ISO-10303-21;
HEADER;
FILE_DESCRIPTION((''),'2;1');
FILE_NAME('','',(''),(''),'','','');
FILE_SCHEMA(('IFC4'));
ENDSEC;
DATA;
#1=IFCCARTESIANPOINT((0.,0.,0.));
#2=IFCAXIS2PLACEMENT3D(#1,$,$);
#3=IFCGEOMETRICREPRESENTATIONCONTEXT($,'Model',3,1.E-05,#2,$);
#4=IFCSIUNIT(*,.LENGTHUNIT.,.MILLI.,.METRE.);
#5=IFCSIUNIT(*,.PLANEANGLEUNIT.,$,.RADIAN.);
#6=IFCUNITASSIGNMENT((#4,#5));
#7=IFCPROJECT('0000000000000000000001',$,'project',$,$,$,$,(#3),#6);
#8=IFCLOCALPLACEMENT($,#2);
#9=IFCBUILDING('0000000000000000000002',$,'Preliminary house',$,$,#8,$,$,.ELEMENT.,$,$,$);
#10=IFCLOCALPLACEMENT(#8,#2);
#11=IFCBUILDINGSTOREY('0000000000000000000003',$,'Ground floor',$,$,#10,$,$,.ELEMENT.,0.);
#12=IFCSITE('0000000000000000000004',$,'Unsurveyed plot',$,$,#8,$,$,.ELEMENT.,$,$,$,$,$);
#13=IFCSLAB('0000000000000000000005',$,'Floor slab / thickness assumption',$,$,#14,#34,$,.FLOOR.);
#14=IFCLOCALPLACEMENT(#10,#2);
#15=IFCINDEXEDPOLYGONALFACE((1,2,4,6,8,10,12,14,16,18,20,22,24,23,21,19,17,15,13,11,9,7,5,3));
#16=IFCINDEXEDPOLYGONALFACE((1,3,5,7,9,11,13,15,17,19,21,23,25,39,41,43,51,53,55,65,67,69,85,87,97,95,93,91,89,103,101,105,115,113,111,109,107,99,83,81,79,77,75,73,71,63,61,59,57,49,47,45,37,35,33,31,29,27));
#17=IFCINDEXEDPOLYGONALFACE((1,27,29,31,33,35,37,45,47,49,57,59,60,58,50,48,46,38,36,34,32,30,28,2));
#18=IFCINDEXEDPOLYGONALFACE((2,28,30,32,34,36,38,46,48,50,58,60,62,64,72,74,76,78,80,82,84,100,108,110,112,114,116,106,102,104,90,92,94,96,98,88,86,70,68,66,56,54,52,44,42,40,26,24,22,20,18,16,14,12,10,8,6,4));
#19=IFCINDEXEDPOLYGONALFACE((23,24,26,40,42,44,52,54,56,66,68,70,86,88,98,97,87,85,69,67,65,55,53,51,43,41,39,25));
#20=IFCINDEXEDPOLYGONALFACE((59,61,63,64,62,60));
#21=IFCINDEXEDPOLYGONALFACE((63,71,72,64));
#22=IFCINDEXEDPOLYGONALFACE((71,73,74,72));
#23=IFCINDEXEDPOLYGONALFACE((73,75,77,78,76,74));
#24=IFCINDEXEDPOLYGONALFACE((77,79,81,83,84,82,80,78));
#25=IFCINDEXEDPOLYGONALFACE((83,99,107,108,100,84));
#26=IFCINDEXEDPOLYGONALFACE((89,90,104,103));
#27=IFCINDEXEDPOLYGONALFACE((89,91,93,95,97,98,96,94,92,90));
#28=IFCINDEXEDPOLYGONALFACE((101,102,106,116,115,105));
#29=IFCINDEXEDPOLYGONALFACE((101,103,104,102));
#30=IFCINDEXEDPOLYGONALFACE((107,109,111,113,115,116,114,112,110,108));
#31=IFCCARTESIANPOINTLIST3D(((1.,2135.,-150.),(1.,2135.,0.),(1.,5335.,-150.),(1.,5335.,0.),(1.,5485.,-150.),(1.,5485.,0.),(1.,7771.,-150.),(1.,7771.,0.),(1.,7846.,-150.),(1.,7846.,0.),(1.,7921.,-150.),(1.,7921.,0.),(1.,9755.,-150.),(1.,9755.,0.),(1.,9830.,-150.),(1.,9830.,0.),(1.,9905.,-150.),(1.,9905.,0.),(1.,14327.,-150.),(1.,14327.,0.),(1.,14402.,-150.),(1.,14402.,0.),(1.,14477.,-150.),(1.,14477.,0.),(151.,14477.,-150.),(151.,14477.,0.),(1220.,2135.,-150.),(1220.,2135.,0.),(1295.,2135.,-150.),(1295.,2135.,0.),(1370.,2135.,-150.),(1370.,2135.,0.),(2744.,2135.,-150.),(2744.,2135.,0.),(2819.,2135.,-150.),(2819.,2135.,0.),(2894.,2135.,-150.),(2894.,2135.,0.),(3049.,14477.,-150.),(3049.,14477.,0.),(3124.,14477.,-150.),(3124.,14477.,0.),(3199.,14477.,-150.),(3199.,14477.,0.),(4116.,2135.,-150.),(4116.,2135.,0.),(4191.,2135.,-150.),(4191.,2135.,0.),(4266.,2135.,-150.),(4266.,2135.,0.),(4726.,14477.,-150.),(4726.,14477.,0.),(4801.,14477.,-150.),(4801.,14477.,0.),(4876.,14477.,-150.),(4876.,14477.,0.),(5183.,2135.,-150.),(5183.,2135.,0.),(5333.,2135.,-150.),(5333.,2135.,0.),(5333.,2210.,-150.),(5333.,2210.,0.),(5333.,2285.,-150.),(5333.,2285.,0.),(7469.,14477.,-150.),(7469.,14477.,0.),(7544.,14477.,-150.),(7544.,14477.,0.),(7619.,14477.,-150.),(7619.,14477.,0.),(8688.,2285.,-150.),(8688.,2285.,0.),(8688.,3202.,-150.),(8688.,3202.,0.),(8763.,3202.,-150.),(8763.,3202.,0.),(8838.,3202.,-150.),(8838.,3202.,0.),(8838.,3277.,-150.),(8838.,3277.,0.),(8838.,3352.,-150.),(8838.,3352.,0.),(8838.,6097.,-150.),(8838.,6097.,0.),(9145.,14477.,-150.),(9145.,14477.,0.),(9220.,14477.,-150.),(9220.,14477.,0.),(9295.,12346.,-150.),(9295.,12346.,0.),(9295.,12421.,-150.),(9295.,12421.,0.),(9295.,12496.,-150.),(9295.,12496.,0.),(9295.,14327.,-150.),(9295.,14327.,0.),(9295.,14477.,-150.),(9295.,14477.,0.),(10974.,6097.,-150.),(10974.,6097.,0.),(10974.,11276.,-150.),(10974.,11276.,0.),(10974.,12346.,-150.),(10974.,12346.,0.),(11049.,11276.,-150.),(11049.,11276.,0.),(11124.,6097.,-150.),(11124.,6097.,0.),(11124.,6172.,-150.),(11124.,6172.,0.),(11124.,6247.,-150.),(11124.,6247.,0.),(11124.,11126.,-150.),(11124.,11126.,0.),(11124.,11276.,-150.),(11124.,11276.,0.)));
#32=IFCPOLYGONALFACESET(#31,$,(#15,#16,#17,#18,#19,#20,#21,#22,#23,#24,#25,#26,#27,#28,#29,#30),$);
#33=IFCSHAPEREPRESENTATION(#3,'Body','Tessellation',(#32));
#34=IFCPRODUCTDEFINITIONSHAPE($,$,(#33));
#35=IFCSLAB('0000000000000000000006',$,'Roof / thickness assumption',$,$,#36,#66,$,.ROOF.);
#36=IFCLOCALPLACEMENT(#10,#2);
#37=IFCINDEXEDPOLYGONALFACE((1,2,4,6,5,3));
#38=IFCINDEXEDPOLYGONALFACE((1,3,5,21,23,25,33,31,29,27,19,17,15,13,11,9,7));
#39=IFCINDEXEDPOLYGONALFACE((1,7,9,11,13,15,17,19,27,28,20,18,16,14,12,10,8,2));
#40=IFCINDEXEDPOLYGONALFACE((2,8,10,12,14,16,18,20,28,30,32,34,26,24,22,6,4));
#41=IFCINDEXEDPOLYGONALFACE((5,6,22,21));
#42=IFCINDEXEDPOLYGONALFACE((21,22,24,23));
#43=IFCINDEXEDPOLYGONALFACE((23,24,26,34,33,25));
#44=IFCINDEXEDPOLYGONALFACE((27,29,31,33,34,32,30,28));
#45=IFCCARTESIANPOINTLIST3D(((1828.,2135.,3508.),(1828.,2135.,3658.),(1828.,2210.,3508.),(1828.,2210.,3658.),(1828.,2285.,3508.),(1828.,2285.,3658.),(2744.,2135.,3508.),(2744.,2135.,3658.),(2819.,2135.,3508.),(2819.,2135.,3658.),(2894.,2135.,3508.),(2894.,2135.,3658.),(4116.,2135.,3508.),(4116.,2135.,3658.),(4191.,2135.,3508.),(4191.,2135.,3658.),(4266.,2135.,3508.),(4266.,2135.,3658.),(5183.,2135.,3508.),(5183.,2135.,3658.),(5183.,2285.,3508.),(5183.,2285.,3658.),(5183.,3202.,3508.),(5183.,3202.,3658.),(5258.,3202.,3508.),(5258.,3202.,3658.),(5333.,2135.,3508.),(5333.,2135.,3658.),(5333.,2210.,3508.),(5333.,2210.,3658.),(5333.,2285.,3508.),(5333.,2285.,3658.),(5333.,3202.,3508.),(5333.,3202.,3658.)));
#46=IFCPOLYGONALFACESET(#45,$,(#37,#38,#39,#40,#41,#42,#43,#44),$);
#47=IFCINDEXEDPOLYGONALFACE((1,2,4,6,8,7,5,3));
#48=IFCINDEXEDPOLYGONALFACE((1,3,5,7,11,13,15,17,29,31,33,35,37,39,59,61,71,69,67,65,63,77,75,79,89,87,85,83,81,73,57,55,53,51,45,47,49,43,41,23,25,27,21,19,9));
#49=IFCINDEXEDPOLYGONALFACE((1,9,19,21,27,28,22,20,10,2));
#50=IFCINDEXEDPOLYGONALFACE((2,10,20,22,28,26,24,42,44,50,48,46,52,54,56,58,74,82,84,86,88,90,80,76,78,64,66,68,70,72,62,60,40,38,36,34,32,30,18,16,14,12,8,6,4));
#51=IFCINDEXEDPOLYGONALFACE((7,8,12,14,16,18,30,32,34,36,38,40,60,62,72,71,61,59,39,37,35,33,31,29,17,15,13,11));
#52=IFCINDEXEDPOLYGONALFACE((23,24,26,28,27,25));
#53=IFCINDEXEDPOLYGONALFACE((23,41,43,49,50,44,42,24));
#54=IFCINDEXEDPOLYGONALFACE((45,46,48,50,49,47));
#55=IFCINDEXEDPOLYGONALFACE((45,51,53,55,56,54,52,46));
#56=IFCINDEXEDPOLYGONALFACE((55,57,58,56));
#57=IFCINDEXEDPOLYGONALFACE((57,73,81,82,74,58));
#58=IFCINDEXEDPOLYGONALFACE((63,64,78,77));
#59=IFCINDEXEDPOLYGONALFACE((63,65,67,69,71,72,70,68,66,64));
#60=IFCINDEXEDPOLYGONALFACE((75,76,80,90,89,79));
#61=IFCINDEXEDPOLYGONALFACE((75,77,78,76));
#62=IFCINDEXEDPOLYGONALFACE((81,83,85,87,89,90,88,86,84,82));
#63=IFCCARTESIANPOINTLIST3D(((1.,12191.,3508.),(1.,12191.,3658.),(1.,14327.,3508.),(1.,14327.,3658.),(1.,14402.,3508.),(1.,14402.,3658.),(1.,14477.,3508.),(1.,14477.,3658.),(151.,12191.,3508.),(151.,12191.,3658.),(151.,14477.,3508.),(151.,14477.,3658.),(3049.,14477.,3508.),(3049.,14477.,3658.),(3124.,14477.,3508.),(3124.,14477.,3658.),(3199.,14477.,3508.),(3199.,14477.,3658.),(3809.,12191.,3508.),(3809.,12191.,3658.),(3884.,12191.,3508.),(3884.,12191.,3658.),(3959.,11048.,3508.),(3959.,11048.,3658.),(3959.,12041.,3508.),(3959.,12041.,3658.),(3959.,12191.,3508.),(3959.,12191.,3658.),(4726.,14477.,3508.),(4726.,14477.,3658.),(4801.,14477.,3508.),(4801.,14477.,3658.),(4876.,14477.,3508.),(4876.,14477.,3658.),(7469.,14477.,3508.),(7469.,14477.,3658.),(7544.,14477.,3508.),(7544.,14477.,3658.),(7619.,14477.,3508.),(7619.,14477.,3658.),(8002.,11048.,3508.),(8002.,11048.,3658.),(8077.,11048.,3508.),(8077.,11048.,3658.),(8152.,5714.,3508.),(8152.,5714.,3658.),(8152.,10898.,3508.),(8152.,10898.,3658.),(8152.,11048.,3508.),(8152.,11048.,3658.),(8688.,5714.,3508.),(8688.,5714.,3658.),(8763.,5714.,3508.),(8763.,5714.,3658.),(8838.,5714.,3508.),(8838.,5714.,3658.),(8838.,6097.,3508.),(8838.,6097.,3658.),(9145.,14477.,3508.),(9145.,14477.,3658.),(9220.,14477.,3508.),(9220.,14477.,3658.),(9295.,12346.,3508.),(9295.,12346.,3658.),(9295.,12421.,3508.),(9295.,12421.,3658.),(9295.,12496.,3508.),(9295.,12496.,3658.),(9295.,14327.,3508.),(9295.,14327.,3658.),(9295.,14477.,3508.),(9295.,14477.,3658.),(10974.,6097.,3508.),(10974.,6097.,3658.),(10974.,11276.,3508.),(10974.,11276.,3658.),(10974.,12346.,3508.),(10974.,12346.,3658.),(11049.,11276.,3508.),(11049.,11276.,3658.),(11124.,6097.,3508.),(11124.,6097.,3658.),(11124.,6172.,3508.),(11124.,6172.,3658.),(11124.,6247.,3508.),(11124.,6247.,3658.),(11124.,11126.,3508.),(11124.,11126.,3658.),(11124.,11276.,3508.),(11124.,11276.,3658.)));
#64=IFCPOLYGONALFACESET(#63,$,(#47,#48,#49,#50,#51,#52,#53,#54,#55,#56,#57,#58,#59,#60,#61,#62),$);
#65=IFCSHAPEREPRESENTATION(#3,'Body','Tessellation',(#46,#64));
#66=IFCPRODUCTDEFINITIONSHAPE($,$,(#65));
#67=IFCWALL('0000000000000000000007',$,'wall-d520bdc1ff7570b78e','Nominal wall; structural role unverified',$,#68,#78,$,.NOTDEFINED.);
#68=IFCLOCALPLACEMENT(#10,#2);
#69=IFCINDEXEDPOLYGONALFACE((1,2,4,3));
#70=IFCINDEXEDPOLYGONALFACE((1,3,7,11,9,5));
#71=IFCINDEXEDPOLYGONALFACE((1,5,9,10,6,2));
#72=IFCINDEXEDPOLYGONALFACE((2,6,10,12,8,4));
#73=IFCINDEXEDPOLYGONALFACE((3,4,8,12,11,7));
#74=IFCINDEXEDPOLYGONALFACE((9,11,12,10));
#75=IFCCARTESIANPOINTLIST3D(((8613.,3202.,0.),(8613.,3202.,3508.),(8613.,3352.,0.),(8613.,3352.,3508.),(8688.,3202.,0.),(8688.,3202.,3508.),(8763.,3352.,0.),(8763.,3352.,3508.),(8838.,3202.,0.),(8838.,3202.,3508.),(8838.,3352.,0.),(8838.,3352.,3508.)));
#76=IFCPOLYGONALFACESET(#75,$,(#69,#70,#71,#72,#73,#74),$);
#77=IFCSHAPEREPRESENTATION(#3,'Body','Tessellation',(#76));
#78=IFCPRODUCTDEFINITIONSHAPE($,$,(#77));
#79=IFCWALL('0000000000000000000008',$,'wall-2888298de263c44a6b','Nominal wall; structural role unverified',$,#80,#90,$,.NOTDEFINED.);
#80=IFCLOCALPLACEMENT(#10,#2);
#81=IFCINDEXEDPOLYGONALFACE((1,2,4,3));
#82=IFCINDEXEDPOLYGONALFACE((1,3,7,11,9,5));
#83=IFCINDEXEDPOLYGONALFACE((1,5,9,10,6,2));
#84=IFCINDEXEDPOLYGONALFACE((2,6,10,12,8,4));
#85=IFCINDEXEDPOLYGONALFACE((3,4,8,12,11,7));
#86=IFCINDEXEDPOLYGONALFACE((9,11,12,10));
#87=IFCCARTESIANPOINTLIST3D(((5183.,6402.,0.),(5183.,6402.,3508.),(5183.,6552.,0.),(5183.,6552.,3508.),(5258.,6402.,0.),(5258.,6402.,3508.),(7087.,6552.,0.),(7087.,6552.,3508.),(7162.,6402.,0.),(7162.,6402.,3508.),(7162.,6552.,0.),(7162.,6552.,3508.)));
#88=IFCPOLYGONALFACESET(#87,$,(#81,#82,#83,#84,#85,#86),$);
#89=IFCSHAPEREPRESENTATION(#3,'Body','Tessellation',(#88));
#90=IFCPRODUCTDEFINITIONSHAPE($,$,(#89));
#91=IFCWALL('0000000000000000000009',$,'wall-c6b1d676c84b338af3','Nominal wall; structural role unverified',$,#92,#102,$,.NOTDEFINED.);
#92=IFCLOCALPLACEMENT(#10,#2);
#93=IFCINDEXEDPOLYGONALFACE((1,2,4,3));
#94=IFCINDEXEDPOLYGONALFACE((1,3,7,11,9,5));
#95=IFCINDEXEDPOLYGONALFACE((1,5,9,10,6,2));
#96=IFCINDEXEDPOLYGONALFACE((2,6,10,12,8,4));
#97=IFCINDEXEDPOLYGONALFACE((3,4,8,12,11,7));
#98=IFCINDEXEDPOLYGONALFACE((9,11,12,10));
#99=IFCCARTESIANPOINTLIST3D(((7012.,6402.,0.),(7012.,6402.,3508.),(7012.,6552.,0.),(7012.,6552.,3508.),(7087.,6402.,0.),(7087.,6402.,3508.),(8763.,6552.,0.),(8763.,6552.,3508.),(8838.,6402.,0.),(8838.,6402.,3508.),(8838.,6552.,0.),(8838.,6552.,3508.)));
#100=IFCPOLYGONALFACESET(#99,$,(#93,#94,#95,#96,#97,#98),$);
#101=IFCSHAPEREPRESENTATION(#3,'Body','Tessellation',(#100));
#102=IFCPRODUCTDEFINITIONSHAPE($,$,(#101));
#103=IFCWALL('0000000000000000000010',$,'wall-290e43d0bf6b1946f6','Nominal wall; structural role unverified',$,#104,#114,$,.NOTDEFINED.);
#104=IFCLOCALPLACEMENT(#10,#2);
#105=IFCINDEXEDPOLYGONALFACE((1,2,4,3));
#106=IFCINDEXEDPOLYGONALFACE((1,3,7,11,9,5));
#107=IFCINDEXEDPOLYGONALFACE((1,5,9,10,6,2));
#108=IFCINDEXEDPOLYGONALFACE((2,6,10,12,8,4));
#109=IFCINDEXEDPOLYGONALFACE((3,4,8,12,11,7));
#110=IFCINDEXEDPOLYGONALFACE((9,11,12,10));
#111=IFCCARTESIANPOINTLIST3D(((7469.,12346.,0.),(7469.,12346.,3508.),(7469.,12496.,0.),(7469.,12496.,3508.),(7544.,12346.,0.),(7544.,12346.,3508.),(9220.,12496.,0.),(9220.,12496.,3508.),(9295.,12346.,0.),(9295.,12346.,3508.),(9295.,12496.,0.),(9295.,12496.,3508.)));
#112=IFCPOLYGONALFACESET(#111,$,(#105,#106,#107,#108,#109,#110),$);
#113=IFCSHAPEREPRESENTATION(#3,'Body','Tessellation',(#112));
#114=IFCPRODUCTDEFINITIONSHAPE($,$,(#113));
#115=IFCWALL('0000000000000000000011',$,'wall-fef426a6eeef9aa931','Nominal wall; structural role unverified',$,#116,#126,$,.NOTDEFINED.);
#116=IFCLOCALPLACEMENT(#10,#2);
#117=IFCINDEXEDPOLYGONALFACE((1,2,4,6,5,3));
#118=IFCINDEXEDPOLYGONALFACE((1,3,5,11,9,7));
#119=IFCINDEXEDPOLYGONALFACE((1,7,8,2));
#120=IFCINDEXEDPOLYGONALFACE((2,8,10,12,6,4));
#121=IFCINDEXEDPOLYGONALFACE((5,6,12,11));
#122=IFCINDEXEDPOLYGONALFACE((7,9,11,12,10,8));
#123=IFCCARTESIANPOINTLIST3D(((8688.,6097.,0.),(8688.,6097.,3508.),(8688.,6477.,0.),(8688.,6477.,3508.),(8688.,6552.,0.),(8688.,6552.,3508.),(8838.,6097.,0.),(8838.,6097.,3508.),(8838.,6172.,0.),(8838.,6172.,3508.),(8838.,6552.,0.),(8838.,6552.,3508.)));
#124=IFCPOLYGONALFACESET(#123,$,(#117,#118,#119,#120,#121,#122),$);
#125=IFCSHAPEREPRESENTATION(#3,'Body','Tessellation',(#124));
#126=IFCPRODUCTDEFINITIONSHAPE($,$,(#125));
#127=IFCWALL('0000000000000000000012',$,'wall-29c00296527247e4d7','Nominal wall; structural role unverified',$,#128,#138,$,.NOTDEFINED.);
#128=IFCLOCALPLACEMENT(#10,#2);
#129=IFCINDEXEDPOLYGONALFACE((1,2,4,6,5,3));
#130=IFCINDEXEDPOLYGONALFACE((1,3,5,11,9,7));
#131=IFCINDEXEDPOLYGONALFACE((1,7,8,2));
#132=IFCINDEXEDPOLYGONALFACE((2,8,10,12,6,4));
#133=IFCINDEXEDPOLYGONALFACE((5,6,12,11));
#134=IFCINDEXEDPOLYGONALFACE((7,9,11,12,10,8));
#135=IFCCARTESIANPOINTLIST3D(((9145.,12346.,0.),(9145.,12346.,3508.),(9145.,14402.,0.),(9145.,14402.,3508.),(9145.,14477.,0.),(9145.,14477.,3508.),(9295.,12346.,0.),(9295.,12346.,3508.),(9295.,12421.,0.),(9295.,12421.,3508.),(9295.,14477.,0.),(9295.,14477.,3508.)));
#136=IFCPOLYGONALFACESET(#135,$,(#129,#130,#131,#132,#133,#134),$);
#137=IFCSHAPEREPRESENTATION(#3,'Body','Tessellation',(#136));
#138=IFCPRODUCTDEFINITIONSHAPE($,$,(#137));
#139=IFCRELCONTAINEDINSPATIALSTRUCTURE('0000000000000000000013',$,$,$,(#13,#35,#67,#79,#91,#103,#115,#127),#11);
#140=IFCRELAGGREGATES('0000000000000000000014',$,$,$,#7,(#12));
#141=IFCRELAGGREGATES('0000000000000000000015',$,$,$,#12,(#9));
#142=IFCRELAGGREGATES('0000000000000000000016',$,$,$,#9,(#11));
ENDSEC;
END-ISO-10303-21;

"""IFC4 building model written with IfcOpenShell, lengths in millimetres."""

from ifc_helpers import new_model, si_unit, frame, origin, place, context, project, spatial, polyline, outline, extrude, element, save


model = new_model("IFC4")

# Units and contexts
model_context = context("Model", 3, precision=1e-05, world=origin())
ifc_project = project(units=[si_unit("LENGTHUNIT", "METRE", prefix="MILLI"), si_unit("PLANEANGLEUNIT", "RADIAN")], contexts=[model_context])

# Site, building, storey
placement_1 = place(None, origin())
site = spatial("IfcSite", under=ifc_project, at=placement_1, Name="Unsurveyed plot", CompositionType="ELEMENT")
building = spatial("IfcBuilding", under=site, at=placement_1, Name="Preliminary house", CompositionType="ELEMENT")
placement_2 = place(placement_1, origin())
storey = spatial("IfcBuildingStorey", under=building, at=placement_2, Name="Ground floor", CompositionType="ELEMENT", Elevation=0.0)

# Slabs
element("IfcSlab", 1, at=placement_2, inside=storey, Name="Floor slab / thickness assumption", PredefinedType="FLOOR", context=model_context, shape_type="SweptSolid", body=[
    extrude(outline(polyline([(4116.0, 2135.0), (2894.0, 2135.0), (2819.0, 2135.0), (2744.0, 2135.0), (1370.0, 2135.0), (1295.0, 2135.0), (1220.0, 2135.0), (1.0, 2135.0), (1.0, 5335.0), (1.0, 5485.0), (1.0, 7771.0), (1.0, 7846.0), (1.0, 7921.0), (1.0, 9755.0), (1.0, 9830.0), (1.0, 9905.0), (1.0, 14327.0), (1.0, 14402.0), (1.0, 14477.0), (151.0, 14477.0), (3049.0, 14477.0), (3124.0, 14477.0), (3199.0, 14477.0), (4726.0, 14477.0), (4801.0, 14477.0), (4876.0, 14477.0), (7469.0, 14477.0), (7544.0, 14477.0), (7619.0, 14477.0), (9145.0, 14477.0), (9220.0, 14477.0), (9295.0, 14477.0), (9295.0, 14327.0), (9295.0, 12496.0), (9295.0, 12421.0), (9295.0, 12346.0), (10974.0, 12346.0), (10974.0, 11276.0), (11049.0, 11276.0), (11124.0, 11276.0), (11124.0, 11126.0), (11124.0, 6247.0), (11124.0, 6172.0), (11124.0, 6097.0), (10974.0, 6097.0), (8838.0, 6097.0), (8838.0, 3352.0), (8838.0, 3277.0), (8838.0, 3202.0), (8763.0, 3202.0), (8688.0, 3202.0), (8688.0, 2285.0), (5333.0, 2285.0), (5333.0, 2210.0), (5333.0, 2135.0), (5183.0, 2135.0), (4266.0, 2135.0), (4191.0, 2135.0), (4116.0, 2135.0)])), frame((0.0, 0.0, -150.0)), (0.0, 0.0, 1.0), 150.0),
])
element("IfcSlab", 2, at=placement_2, inside=storey, Name="Roof / thickness assumption", PredefinedType="ROOF", context=model_context, shape_type="SweptSolid", body=[
    extrude(outline(polyline([(1828.0, 2210.0), (1828.0, 2285.0), (5183.0, 2285.0), (5183.0, 3202.0), (5258.0, 3202.0), (5333.0, 3202.0), (5333.0, 2285.0), (5333.0, 2210.0), (5333.0, 2135.0), (5183.0, 2135.0), (4266.0, 2135.0), (4191.0, 2135.0), (4116.0, 2135.0), (2894.0, 2135.0), (2819.0, 2135.0), (2744.0, 2135.0), (1828.0, 2135.0), (1828.0, 2210.0)])), frame((0.0, 0.0, 3508.0)), (0.0, 0.0, 1.0), 150.0),
    extrude(outline(polyline([(1.0, 14402.0), (1.0, 14477.0), (151.0, 14477.0), (3049.0, 14477.0), (3124.0, 14477.0), (3199.0, 14477.0), (4726.0, 14477.0), (4801.0, 14477.0), (4876.0, 14477.0), (7469.0, 14477.0), (7544.0, 14477.0), (7619.0, 14477.0), (9145.0, 14477.0), (9220.0, 14477.0), (9295.0, 14477.0), (9295.0, 14327.0), (9295.0, 12496.0), (9295.0, 12421.0), (9295.0, 12346.0), (10974.0, 12346.0), (10974.0, 11276.0), (11049.0, 11276.0), (11124.0, 11276.0), (11124.0, 11126.0), (11124.0, 6247.0), (11124.0, 6172.0), (11124.0, 6097.0), (10974.0, 6097.0), (8838.0, 6097.0), (8838.0, 5714.0), (8763.0, 5714.0), (8688.0, 5714.0), (8152.0, 5714.0), (8152.0, 10898.0), (8152.0, 11048.0), (8077.0, 11048.0), (8002.0, 11048.0), (3959.0, 11048.0), (3959.0, 12041.0), (3959.0, 12191.0), (3884.0, 12191.0), (3809.0, 12191.0), (151.0, 12191.0), (1.0, 12191.0), (1.0, 14327.0), (1.0, 14402.0)])), frame((0.0, 0.0, 3508.0)), (0.0, 0.0, 1.0), 150.0),
])

# Walls
element("IfcWall", 3, at=placement_2, inside=storey, Name="wall-d520bdc1ff7570b78e", Description="Nominal wall; structural role unverified", PredefinedType="NOTDEFINED", context=model_context, shape_type="SweptSolid", body=[
    extrude(outline(polyline([(8763.0, 3352.0), (8838.0, 3352.0), (8838.0, 3202.0), (8688.0, 3202.0), (8613.0, 3202.0), (8613.0, 3352.0), (8763.0, 3352.0)])), origin(), (0.0, 0.0, 1.0), 3508.0),
])
element("IfcWall", 4, at=placement_2, inside=storey, Name="wall-2888298de263c44a6b", Description="Nominal wall; structural role unverified", PredefinedType="NOTDEFINED", context=model_context, shape_type="SweptSolid", body=[
    extrude(outline(polyline([(7087.0, 6552.0), (7162.0, 6552.0), (7162.0, 6402.0), (5258.0, 6402.0), (5183.0, 6402.0), (5183.0, 6552.0), (7087.0, 6552.0)])), origin(), (0.0, 0.0, 1.0), 3508.0),
])

# Wall
element("IfcWall", 5, at=placement_2, inside=storey, Name="wall-c6b1d676c84b338af3", Description="Nominal wall; structural role unverified", PredefinedType="NOTDEFINED", context=model_context, shape_type="SweptSolid", body=[
    extrude(outline(polyline([(8763.0, 6552.0), (8838.0, 6552.0), (8838.0, 6402.0), (7087.0, 6402.0), (7012.0, 6402.0), (7012.0, 6552.0), (8763.0, 6552.0)])), origin(), (0.0, 0.0, 1.0), 3508.0),
])

# Wall
element("IfcWall", 6, at=placement_2, inside=storey, Name="wall-290e43d0bf6b1946f6", Description="Nominal wall; structural role unverified", PredefinedType="NOTDEFINED", context=model_context, shape_type="SweptSolid", body=[
    extrude(outline(polyline([(9220.0, 12496.0), (9295.0, 12496.0), (9295.0, 12346.0), (7544.0, 12346.0), (7469.0, 12346.0), (7469.0, 12496.0), (9220.0, 12496.0)])), origin(), (0.0, 0.0, 1.0), 3508.0),
])

# Wall
element("IfcWall", 7, at=placement_2, inside=storey, Name="wall-fef426a6eeef9aa931", Description="Nominal wall; structural role unverified", PredefinedType="NOTDEFINED", context=model_context, shape_type="SweptSolid", body=[
    extrude(outline(polyline([(8688.0, 6477.0), (8688.0, 6552.0), (8838.0, 6552.0), (8838.0, 6172.0), (8838.0, 6097.0), (8688.0, 6097.0), (8688.0, 6477.0)])), origin(), (0.0, 0.0, 1.0), 3508.0),
])

# Wall
element("IfcWall", 8, at=placement_2, inside=storey, Name="wall-29c00296527247e4d7", Description="Nominal wall; structural role unverified", PredefinedType="NOTDEFINED", context=model_context, shape_type="SweptSolid", body=[
    extrude(outline(polyline([(9145.0, 14402.0), (9145.0, 14477.0), (9295.0, 14477.0), (9295.0, 12421.0), (9295.0, 12346.0), (9145.0, 12346.0), (9145.0, 14402.0)])), origin(), (0.0, 0.0, 1.0), 3508.0),
])

save(model, "model.ifc")
